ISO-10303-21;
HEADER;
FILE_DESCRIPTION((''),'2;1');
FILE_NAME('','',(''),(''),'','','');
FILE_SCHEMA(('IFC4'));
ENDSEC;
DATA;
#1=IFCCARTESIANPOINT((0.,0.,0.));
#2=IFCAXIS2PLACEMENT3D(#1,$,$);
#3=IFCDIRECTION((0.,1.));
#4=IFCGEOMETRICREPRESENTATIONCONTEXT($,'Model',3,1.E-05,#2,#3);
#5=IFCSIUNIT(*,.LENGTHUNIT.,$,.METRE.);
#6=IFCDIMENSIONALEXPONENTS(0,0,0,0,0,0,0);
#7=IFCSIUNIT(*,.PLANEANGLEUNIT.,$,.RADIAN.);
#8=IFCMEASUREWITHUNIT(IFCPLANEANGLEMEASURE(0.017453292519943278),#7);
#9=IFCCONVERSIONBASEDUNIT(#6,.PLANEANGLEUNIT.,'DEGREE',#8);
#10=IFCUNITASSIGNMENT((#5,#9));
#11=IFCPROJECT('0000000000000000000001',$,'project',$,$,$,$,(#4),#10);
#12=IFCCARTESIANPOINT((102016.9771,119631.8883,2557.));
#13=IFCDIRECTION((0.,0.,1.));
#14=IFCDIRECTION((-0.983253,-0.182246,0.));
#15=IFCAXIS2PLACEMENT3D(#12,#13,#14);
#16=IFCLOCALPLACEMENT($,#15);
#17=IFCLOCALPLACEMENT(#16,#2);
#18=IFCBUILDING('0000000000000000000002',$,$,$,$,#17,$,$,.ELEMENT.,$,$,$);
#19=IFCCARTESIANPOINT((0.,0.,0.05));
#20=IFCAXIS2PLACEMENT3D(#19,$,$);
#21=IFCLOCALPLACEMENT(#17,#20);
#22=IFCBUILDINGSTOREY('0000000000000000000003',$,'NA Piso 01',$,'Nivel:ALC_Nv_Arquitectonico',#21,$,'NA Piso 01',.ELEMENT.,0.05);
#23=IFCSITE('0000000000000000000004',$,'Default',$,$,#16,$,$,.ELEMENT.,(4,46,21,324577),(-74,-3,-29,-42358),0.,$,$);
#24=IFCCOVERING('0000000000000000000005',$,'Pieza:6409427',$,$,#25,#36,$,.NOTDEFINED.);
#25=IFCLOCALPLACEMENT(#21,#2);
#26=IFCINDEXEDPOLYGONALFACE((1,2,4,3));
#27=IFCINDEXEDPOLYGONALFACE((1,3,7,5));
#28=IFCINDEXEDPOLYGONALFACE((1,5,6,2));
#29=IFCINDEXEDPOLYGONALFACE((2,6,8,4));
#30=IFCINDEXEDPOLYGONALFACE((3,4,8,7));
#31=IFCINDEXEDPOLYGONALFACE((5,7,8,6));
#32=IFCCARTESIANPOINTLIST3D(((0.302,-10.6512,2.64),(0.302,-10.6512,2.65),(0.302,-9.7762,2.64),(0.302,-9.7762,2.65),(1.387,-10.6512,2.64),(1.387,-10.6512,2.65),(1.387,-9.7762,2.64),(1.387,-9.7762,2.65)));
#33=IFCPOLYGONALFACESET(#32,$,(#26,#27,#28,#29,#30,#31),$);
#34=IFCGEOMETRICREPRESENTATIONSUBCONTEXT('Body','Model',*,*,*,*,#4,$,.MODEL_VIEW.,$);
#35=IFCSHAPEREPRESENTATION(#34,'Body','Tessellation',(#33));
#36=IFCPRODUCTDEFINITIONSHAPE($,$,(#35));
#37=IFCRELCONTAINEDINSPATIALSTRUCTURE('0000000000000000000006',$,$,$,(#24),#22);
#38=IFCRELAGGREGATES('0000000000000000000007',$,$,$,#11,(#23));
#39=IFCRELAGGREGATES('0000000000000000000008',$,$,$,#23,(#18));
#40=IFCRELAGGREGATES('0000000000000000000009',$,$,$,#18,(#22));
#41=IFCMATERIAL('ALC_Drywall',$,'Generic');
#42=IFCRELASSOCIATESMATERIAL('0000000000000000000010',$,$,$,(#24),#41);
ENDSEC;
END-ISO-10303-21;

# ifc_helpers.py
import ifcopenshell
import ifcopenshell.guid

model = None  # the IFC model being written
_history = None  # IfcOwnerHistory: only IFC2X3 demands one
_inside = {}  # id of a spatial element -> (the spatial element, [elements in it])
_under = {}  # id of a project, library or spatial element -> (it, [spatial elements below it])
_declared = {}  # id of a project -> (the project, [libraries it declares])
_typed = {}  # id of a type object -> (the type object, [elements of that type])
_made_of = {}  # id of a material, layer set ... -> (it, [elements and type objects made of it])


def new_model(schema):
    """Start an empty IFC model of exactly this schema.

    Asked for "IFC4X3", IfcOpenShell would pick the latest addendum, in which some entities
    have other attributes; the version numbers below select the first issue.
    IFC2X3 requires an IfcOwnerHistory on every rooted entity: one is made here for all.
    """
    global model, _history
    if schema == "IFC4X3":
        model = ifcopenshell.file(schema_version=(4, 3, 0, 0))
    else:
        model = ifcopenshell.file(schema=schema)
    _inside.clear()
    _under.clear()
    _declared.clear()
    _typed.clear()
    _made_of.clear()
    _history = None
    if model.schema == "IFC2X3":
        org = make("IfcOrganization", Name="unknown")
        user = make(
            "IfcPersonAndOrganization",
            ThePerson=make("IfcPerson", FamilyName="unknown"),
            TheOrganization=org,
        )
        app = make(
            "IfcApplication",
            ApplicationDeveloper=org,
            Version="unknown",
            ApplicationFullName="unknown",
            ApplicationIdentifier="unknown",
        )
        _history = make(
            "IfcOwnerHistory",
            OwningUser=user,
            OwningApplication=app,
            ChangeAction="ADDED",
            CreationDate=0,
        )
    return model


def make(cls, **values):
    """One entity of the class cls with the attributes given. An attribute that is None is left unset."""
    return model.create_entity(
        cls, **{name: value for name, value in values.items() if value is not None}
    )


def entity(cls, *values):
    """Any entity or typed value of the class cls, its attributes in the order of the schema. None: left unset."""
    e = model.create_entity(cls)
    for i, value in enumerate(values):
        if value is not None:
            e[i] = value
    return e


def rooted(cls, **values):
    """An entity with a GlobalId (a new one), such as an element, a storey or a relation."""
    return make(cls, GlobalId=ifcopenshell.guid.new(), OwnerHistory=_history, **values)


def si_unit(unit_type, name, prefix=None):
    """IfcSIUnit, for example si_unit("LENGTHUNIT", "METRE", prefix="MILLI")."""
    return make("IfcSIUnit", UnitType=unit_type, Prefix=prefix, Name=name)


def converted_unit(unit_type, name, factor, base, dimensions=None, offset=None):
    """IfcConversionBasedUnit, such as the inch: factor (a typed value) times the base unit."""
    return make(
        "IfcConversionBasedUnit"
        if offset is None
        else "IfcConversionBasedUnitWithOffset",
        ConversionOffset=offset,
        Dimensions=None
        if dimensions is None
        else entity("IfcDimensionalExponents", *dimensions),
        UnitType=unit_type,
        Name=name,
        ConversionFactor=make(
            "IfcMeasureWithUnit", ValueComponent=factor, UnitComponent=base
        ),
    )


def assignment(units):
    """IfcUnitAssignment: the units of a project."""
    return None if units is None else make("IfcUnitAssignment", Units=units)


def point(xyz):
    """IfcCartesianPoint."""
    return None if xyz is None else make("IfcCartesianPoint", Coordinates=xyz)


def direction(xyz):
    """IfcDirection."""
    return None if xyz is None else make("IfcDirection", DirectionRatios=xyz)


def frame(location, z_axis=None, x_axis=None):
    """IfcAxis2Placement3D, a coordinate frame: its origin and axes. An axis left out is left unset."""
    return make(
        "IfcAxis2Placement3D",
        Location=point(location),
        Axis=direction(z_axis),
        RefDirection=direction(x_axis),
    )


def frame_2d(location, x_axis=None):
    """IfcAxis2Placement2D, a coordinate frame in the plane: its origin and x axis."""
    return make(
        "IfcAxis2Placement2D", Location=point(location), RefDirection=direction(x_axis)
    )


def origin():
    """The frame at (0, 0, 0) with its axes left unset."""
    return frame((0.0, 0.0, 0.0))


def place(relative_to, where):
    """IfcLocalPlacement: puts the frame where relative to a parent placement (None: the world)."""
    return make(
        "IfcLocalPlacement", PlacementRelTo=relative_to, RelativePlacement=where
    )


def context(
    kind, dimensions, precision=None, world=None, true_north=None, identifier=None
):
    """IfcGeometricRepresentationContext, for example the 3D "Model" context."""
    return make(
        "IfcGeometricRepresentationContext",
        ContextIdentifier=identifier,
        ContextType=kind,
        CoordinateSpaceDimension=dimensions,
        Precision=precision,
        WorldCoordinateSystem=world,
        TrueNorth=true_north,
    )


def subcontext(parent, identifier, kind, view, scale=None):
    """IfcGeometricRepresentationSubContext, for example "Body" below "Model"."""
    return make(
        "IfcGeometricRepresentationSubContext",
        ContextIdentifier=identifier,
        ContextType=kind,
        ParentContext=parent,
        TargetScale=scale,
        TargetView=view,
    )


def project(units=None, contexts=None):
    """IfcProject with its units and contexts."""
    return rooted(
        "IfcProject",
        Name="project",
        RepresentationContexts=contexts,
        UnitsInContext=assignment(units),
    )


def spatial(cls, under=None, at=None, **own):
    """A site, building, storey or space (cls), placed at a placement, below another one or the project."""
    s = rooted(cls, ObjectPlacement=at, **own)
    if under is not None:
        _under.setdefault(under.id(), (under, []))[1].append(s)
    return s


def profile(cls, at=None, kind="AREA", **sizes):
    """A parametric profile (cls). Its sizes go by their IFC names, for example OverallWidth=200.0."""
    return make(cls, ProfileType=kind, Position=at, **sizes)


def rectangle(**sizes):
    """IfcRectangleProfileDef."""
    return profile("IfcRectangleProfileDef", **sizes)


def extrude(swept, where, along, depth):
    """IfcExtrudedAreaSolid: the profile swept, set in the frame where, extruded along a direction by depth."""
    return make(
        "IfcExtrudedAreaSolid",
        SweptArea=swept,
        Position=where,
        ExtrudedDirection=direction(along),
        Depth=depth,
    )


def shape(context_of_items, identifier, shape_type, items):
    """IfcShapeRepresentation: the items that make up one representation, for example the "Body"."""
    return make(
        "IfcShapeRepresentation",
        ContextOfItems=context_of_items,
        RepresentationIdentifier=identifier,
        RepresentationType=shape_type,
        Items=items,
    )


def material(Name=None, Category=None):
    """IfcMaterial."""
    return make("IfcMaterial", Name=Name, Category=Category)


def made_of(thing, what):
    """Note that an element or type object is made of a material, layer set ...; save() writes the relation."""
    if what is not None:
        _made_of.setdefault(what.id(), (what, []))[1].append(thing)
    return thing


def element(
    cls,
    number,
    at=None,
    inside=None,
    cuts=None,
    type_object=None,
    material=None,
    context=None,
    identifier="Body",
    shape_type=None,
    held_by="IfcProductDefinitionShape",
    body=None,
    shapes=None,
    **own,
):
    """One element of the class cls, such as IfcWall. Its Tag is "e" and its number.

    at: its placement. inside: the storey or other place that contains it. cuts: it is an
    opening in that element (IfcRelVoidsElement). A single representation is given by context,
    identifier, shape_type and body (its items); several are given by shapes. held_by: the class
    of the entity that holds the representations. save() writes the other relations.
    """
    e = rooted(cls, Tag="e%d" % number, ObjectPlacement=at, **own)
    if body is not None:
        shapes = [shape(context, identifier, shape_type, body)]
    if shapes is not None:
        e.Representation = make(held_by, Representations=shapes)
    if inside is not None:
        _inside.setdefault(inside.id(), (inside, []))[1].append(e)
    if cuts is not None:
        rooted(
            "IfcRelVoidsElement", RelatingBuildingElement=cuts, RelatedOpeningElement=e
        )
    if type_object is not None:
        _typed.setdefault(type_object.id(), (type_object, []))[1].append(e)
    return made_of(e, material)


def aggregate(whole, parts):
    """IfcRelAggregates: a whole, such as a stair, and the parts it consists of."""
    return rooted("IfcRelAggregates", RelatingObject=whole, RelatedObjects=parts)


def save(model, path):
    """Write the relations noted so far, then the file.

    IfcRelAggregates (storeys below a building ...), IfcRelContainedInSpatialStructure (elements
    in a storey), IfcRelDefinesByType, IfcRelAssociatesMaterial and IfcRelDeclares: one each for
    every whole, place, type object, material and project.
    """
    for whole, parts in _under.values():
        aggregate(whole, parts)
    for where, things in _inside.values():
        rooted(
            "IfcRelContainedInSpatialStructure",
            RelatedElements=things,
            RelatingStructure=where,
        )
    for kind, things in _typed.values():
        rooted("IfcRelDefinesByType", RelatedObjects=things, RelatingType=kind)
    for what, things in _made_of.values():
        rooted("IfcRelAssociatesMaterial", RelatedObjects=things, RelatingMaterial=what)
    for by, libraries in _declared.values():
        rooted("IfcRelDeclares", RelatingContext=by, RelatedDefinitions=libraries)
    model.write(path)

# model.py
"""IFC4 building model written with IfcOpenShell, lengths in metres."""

from ifc_helpers import new_model, entity, si_unit, converted_unit, direction, frame, frame_2d, origin, place, context, subcontext, project, spatial, rectangle, extrude, material, element, save


model = new_model("IFC4")

# Units and contexts
model_context = context("Model", 3, precision=1e-05, world=origin(), true_north=direction((0.0, 1.0)))
body_context = subcontext(model_context, "Body", "Model", "MODEL_VIEW")
ifc_project = project(units=[si_unit("LENGTHUNIT", "METRE"), converted_unit("PLANEANGLEUNIT", "DEGREE", entity("IfcPlaneAngleMeasure", 0.017453292519943278), si_unit("PLANEANGLEUNIT", "RADIAN"), dimensions=[0, 0, 0, 0, 0, 0, 0])], contexts=[model_context])

# Site, building, storey
site_placement = place(None, frame((102016.9771, 119631.8883, 2557.0), z_axis=(0.0, 0.0, 1.0), x_axis=(-0.983253, -0.182246, 0.0)))
site = spatial("IfcSite", under=ifc_project, at=site_placement, Name="Default", CompositionType="ELEMENT", RefLatitude=(4, 46, 21, 324577), RefLongitude=(-74, -3, -29, -42358), RefElevation=0.0)
building_placement = place(site_placement, origin())
building = spatial("IfcBuilding", under=site, at=building_placement, CompositionType="ELEMENT")
storey_placement = place(building_placement, frame((0.0, 0.0, 0.05)))
storey = spatial("IfcBuildingStorey", under=building, at=storey_placement, Name="NA Piso 01", ObjectType="Nivel:ALC_Nv_Arquitectonico", LongName="NA Piso 01", CompositionType="ELEMENT", Elevation=0.05)

# Covering
ifc_material_1 = material(Name="ALC_Drywall", Category="Generic")
covering_placement = place(storey_placement, frame((0.0, 0.0, 2.64)))
element("IfcCovering", 1, at=covering_placement, inside=storey, material=ifc_material_1, Name="Pieza:6409427", PredefinedType="NOTDEFINED", context=body_context, shape_type="SweptSolid", body=[
    extrude(rectangle(XDim=0.875, YDim=1.085, at=frame_2d((0.0, 0.0), x_axis=(1.0, 0.0))), frame((0.8445, -10.2137, 0.0), z_axis=(0.0, 0.0, 1.0), x_axis=(0.0, -1.0, 0.0)), (0.0, 0.0, 1.0), 0.01),
])

save(model, "model.ifc")
